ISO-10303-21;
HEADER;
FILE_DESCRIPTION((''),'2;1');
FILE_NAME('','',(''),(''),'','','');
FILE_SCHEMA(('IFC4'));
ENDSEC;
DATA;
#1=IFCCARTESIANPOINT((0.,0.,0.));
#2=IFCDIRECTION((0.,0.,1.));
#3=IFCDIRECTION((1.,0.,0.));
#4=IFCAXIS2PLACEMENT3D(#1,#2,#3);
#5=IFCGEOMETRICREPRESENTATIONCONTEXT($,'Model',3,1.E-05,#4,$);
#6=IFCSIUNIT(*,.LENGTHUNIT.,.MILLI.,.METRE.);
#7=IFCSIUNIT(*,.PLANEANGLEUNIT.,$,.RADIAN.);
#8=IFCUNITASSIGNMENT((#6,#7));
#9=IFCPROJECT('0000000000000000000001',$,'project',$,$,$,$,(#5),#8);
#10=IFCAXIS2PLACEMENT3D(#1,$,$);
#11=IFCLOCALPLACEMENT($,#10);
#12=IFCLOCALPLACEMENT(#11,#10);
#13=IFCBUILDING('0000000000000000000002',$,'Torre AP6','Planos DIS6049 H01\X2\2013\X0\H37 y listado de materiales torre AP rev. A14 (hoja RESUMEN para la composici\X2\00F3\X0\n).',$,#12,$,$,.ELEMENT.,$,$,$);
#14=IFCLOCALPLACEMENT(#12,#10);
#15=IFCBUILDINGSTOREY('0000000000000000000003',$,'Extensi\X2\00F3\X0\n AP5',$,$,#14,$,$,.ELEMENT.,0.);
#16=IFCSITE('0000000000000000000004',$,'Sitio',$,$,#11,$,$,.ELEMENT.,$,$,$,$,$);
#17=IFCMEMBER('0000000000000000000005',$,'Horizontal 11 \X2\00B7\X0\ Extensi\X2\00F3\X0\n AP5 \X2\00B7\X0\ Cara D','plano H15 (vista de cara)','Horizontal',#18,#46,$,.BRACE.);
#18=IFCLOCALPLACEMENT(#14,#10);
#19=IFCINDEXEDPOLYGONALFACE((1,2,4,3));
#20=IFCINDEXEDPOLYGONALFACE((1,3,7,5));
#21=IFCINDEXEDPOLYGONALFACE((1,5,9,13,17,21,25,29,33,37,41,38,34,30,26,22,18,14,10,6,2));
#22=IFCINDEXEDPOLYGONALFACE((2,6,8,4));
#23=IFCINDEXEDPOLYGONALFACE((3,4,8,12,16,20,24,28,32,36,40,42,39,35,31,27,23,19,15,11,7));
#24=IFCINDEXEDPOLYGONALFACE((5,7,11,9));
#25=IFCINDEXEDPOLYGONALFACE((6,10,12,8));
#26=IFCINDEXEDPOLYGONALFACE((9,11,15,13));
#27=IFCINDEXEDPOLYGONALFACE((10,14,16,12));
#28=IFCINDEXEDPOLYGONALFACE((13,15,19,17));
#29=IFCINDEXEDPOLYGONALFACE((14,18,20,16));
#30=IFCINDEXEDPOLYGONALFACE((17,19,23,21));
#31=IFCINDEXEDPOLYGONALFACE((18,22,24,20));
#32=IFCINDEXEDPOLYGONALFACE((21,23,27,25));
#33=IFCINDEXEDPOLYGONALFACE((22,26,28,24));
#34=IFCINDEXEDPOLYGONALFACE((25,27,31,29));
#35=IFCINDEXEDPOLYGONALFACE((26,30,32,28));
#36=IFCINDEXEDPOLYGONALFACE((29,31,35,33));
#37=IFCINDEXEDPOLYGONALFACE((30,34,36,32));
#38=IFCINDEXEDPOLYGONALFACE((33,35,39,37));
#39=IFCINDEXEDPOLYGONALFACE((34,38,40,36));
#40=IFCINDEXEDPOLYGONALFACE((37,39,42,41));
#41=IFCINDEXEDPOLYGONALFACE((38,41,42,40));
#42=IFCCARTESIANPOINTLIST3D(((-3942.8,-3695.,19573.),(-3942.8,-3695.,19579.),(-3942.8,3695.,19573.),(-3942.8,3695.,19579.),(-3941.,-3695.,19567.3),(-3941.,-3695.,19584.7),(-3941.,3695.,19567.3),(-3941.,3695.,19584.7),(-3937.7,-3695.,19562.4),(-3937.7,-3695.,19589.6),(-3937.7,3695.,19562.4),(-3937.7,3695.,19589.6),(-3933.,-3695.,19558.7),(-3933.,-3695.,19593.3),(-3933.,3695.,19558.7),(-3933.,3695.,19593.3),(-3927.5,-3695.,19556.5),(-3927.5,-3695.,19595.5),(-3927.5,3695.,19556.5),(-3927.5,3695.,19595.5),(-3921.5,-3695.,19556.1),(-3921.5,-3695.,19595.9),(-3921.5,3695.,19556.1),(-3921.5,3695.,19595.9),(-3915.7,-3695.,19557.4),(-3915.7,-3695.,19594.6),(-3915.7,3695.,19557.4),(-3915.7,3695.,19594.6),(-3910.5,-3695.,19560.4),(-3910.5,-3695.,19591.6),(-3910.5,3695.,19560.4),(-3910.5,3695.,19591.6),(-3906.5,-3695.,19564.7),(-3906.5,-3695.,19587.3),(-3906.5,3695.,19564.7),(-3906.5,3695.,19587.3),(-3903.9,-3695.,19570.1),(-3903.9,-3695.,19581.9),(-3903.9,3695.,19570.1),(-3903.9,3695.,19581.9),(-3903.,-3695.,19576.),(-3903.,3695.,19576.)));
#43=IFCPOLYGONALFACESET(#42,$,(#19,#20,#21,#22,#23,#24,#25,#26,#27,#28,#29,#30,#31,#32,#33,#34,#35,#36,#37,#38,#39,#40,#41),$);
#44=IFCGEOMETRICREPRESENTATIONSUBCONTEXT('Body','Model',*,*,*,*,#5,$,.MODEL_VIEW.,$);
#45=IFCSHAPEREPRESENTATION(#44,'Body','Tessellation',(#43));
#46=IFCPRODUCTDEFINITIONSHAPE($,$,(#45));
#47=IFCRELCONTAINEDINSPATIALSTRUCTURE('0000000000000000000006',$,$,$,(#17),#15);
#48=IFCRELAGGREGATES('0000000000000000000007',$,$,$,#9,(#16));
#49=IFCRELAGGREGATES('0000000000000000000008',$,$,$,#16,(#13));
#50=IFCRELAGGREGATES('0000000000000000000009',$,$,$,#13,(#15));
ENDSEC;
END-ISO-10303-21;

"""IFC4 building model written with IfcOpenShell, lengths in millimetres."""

from ifc_helpers import new_model, si_unit, frame, origin, origin_with_axes, place, context, subcontext, project, spatial, circle, extrude, element, save


model = new_model("IFC4")

# Units and contexts
model_context = context("Model", 3, precision=1e-05, world=origin_with_axes())
body_context = subcontext(model_context, "Body", "Model", "MODEL_VIEW")
ifc_project = project(units=[si_unit("LENGTHUNIT", "METRE", prefix="MILLI"), si_unit("PLANEANGLEUNIT", "RADIAN")], contexts=[model_context])

# Site, building, storey
site_placement = place(None, origin())
site = spatial("IfcSite", under=ifc_project, at=site_placement, Name="Sitio", CompositionType="ELEMENT")
building_placement = place(site_placement, origin())
building = spatial("IfcBuilding", under=site, at=building_placement, Name="Torre AP6", Description="Planos DIS6049 H01–H37 y listado de materiales torre AP rev. A14 (hoja RESUMEN para la composición).", CompositionType="ELEMENT")
storey_placement = place(building_placement, origin())
storey = spatial("IfcBuildingStorey", under=building, at=storey_placement, Name="Extensión AP5", CompositionType="ELEMENT", Elevation=0.0)

# Member
for number, where, z_axis, x_axis, name in (
    (1, (-3923.0, -3695.0, 19576.0), (0.0, 1.0, 0.0), (1.0, 0.0, 0.0), "Horizontal 11 · Extensión AP5 · Cara D"),
):
    element("IfcMember", number, at=place(storey_placement, frame(where, z_axis=z_axis, x_axis=x_axis)), inside=storey, Name=name, Description="plano H15 (vista de cara)", ObjectType="Horizontal", PredefinedType="BRACE", context=body_context, shape_type="SweptSolid", body=[
        extrude(circle(Radius=20.0), None, (0.0, 0.0, 1.0), 7390.0),
    ])

save(model, "model.ifc")
